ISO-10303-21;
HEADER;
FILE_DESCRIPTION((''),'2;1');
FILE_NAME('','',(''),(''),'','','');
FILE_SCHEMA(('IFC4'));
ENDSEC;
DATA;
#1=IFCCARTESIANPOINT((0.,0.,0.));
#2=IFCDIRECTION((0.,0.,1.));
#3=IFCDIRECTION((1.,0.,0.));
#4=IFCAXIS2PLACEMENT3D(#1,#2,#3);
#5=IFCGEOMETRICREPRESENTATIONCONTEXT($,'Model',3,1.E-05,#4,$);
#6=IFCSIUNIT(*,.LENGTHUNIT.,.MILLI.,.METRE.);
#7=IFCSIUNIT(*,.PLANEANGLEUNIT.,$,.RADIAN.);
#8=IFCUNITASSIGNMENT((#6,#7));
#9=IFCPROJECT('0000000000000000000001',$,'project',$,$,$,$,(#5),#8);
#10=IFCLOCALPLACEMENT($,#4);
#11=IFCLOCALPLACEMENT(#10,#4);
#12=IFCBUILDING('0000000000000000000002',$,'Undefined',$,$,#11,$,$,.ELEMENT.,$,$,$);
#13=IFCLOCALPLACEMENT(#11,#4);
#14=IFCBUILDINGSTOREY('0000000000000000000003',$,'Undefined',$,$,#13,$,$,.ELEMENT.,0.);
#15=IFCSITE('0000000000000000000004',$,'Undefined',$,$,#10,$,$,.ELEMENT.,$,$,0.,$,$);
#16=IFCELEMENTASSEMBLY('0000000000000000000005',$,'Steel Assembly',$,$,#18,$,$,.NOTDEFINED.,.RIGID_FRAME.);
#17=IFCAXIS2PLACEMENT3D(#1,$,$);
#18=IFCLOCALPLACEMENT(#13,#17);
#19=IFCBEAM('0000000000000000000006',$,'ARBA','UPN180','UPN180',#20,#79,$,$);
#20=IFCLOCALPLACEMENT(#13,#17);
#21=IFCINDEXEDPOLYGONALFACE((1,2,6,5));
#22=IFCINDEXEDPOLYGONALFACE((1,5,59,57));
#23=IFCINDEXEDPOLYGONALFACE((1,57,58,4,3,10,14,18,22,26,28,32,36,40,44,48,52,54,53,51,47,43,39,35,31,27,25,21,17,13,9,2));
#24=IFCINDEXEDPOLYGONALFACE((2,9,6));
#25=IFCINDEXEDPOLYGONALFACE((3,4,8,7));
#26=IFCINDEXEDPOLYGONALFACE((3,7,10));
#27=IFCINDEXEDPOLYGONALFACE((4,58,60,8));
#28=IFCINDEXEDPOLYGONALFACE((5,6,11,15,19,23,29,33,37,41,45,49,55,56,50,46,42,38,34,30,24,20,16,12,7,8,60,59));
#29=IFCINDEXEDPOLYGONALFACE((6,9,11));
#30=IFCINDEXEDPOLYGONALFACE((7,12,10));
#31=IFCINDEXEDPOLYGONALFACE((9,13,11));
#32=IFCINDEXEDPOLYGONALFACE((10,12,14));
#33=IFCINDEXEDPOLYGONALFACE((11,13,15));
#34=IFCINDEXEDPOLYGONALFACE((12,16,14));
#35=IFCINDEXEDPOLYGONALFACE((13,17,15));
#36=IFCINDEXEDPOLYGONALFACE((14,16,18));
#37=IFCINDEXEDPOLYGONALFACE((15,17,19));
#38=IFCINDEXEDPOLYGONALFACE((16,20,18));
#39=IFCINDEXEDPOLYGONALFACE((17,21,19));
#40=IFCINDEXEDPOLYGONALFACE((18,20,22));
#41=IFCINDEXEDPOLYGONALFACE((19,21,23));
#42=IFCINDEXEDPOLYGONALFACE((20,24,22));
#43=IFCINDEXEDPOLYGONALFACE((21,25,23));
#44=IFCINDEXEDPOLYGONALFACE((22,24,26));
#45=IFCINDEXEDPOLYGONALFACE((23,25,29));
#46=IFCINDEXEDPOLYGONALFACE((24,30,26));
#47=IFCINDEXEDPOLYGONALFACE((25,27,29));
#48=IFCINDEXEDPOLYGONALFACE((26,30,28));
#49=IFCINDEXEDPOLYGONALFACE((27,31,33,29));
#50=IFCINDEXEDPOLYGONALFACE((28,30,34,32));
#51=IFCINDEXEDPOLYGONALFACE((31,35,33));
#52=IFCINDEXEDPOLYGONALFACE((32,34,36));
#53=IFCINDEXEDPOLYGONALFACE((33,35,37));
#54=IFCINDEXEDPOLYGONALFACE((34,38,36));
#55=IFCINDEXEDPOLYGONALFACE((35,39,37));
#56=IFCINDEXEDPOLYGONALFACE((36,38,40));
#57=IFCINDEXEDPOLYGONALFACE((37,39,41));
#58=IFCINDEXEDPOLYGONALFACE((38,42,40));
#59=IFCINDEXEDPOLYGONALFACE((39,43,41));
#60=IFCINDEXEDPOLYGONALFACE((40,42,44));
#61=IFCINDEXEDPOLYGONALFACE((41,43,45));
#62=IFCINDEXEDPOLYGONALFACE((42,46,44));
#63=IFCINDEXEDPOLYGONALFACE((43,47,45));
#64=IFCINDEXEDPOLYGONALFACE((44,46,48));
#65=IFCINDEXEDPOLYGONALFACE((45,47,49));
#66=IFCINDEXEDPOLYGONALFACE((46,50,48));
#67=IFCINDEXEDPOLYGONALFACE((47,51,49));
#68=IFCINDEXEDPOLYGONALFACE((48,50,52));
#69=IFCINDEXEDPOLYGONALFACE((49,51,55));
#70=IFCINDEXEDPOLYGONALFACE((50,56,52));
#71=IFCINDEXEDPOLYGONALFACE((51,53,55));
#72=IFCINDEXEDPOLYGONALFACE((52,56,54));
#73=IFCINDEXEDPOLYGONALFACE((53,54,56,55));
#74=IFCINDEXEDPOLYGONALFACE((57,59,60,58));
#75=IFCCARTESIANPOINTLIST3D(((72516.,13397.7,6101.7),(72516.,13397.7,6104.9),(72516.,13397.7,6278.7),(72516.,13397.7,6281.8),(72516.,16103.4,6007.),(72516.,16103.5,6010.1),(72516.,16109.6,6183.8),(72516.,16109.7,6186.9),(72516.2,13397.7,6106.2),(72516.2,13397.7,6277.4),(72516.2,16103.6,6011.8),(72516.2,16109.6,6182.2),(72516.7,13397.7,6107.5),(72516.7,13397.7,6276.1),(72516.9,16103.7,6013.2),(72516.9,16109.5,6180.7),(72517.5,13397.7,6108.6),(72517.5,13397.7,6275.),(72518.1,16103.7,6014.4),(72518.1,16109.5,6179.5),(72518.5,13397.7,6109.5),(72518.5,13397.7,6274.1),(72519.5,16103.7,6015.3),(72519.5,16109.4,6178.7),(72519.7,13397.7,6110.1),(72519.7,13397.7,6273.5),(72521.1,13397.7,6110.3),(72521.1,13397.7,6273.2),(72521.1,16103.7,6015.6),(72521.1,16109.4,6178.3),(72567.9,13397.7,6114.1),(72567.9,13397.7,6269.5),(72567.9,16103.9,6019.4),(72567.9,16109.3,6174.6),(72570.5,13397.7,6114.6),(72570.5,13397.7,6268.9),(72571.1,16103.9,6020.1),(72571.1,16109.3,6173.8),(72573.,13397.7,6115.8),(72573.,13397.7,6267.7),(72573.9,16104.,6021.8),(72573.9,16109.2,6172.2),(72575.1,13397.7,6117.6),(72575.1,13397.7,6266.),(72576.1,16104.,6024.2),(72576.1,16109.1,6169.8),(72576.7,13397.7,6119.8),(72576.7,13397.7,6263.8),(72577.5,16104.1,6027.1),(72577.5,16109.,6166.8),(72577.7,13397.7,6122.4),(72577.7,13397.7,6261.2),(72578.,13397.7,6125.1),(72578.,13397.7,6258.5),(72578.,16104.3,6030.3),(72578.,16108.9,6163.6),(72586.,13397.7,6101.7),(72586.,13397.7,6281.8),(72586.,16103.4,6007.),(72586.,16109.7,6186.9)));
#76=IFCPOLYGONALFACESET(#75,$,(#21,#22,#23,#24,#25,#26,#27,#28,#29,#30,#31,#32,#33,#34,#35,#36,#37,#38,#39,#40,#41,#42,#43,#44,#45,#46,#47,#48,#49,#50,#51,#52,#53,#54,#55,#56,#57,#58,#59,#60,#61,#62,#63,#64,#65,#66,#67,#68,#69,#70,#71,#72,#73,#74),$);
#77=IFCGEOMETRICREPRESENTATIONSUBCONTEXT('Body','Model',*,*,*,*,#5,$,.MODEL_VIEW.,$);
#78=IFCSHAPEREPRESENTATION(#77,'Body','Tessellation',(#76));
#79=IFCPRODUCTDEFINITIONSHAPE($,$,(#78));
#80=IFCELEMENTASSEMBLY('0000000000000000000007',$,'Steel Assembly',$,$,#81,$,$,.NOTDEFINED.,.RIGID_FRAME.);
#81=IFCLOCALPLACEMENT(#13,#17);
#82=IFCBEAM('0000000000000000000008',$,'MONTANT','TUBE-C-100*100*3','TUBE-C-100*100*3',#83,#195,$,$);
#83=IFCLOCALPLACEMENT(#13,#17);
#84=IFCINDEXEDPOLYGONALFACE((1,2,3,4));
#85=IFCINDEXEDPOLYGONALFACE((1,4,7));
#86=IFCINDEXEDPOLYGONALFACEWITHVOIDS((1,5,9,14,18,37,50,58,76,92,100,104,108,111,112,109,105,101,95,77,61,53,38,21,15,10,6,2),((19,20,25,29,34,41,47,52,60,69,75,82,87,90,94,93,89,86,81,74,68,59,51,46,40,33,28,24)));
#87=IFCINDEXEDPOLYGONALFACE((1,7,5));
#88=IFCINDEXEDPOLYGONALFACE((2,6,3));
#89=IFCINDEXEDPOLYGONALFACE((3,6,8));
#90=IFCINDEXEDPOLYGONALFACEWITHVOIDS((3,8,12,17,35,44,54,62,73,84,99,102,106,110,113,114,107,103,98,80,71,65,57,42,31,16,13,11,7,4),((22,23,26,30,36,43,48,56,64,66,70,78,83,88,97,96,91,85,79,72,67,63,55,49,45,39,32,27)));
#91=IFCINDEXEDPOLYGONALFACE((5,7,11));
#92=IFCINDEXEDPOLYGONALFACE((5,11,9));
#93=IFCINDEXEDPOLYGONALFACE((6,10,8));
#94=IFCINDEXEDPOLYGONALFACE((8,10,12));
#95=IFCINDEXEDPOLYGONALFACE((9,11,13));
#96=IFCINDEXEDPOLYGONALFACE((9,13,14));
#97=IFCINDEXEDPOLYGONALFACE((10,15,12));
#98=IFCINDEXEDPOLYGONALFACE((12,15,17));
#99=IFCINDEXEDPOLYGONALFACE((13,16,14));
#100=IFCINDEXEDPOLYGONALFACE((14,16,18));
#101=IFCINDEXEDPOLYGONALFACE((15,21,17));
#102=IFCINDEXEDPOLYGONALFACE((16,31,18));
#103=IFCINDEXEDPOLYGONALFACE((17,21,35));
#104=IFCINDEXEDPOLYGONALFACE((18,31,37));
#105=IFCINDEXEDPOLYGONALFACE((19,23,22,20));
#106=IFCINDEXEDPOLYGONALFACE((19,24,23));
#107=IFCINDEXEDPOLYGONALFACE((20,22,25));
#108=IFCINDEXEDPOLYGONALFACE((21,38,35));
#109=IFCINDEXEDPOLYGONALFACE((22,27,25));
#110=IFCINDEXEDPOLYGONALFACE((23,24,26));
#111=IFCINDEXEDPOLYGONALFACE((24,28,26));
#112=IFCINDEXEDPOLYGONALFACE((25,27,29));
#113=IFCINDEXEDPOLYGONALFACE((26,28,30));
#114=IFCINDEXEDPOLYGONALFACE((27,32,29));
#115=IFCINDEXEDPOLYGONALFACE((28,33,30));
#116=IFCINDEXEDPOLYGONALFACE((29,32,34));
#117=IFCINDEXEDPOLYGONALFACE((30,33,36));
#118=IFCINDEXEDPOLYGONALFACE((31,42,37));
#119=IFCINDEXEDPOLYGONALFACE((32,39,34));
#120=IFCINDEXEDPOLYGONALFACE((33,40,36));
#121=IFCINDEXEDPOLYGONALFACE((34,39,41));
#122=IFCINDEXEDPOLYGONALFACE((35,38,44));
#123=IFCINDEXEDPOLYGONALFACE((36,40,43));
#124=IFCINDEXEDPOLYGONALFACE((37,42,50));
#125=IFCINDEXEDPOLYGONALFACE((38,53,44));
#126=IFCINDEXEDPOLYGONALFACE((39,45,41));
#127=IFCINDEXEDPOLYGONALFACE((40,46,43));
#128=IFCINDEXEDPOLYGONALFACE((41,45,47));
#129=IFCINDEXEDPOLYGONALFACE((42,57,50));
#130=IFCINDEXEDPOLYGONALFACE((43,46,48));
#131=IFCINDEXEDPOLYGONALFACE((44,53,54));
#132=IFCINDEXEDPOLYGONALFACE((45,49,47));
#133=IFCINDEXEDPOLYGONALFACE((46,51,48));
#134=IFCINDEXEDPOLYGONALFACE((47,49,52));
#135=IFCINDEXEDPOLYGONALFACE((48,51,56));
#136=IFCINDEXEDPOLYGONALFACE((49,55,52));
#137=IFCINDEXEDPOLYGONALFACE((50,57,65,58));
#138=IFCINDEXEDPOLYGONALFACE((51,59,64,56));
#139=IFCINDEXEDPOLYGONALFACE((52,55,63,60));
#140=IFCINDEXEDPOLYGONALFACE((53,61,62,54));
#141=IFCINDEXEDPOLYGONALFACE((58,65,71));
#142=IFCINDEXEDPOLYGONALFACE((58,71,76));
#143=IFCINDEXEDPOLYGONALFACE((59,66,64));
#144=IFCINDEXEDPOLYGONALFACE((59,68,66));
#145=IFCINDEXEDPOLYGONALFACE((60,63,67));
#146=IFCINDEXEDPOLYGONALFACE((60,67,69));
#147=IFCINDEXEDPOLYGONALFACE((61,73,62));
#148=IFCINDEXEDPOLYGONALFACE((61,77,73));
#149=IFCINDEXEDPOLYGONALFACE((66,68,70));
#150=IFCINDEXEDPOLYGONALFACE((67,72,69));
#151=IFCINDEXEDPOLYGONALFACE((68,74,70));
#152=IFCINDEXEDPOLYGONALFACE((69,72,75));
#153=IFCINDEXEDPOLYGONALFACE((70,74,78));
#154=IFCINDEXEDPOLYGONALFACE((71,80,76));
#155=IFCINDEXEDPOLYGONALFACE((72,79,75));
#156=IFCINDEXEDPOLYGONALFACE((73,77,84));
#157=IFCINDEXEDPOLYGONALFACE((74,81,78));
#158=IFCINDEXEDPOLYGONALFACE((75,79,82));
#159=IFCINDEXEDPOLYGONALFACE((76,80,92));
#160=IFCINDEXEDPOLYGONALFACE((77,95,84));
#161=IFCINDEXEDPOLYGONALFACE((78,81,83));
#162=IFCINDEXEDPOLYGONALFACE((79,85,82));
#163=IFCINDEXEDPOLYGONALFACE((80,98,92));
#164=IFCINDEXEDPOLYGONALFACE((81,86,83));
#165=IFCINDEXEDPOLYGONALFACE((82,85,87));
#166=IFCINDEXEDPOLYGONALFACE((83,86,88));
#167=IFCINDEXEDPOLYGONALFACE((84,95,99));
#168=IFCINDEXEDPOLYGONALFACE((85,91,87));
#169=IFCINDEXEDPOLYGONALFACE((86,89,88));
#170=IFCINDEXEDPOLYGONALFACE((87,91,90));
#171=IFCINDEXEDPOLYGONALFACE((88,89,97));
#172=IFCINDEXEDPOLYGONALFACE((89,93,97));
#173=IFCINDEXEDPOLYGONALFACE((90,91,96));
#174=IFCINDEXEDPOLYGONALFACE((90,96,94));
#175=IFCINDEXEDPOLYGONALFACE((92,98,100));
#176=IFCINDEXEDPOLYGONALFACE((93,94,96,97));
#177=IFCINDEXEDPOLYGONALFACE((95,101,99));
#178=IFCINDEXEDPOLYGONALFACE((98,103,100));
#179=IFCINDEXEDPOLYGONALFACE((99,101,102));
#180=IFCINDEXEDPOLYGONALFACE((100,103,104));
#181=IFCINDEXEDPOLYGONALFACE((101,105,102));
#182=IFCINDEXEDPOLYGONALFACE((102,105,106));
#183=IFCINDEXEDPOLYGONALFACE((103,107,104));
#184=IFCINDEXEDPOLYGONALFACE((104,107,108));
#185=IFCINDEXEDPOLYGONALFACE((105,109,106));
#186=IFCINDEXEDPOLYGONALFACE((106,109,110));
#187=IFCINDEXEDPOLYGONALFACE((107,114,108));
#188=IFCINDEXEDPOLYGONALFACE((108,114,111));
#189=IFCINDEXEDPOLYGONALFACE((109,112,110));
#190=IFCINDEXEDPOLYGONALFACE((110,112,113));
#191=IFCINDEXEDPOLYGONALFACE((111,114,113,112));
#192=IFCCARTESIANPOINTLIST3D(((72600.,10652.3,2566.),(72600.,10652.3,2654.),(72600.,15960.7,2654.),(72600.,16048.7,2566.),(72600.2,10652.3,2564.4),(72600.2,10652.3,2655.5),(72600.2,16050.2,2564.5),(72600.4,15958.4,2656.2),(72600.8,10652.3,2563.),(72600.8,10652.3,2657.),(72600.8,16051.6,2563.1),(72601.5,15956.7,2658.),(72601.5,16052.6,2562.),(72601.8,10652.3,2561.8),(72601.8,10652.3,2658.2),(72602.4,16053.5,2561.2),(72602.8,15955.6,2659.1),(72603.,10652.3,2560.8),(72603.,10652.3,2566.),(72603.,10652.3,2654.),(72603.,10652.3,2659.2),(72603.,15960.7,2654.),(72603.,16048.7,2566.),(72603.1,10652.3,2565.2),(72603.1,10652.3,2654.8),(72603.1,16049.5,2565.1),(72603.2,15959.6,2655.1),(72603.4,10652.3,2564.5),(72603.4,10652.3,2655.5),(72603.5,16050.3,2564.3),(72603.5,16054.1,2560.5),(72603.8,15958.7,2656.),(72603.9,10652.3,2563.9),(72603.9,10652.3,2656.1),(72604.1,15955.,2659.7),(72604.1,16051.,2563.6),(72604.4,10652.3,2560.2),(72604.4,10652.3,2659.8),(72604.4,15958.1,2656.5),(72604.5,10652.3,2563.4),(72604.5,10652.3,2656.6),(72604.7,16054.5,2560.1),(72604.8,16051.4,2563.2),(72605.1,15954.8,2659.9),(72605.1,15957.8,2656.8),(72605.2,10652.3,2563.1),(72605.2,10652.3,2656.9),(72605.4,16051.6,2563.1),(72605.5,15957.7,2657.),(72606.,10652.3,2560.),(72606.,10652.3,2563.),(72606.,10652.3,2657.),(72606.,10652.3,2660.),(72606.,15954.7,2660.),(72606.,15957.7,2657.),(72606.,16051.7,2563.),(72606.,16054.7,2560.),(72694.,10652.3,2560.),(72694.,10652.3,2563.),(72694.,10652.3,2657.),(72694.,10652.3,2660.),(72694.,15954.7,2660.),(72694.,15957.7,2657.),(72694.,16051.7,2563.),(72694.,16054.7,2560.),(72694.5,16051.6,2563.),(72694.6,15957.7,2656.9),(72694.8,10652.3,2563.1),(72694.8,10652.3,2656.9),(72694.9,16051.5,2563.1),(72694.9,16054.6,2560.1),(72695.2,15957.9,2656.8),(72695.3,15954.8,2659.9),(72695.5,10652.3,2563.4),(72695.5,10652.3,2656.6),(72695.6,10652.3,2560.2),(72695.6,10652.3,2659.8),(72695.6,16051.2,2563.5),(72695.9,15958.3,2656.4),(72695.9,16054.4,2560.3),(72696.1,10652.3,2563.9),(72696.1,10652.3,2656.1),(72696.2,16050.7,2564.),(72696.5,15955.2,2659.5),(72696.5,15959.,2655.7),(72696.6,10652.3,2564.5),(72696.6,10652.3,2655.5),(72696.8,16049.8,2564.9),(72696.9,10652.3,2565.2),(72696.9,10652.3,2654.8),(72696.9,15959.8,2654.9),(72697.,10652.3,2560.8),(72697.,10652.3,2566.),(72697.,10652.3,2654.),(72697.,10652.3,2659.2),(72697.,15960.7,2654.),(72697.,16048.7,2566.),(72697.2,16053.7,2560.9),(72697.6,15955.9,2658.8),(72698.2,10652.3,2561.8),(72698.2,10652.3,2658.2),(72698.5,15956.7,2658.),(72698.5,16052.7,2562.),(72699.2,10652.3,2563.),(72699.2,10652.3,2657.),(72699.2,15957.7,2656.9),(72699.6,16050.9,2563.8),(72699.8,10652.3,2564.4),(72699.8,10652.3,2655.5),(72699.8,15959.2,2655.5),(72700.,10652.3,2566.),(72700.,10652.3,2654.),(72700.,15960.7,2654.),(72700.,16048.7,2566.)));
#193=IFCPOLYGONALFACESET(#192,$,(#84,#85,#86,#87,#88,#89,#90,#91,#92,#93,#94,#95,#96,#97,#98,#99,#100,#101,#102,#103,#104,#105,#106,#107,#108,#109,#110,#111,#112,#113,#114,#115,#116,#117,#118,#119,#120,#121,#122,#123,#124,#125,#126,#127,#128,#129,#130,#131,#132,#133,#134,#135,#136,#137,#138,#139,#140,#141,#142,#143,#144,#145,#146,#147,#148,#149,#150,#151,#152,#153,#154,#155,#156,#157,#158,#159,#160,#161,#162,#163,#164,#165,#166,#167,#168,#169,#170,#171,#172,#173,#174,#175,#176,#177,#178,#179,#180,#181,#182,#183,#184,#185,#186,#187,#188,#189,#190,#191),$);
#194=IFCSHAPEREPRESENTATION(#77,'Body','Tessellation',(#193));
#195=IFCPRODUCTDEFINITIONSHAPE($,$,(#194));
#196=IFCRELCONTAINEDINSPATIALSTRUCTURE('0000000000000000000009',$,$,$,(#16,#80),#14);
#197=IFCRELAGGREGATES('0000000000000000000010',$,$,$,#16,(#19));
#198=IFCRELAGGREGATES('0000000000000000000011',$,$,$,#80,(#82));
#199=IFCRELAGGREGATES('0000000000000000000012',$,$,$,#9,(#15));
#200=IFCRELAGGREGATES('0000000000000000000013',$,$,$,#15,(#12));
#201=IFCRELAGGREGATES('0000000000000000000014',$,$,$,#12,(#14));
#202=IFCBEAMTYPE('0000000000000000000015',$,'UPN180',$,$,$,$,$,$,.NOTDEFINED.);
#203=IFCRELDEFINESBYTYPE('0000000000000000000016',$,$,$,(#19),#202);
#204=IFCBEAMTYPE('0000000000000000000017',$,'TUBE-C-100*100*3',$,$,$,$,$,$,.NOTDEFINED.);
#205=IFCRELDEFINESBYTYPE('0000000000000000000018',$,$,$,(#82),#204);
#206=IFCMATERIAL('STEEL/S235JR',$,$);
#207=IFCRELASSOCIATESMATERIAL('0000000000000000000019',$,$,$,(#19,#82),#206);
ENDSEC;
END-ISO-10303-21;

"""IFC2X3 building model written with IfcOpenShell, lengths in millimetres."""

from ifc_helpers import new_model, si_unit, frame, origin_with_axes, origin_2d_with_axis, place, context, subcontext, project, spatial, hollow_rectangle, u_section, extrude, clip, halfspace, material, type_object, element, aggregate, save


model = new_model("IFC2X3")

# Units and contexts
model_context = context("Model", 3, precision=1e-05, world=origin_with_axes())
body_context = subcontext(model_context, "Body", "Model", "MODEL_VIEW")
ifc_project = project(units=[si_unit("LENGTHUNIT", "METRE", prefix="MILLI"), si_unit("PLANEANGLEUNIT", "RADIAN")], contexts=[model_context])

# Site, building, storey
site_placement = place(None, origin_with_axes())
site = spatial("IfcSite", under=ifc_project, at=site_placement, Name="Undefined", CompositionType="ELEMENT", RefElevation=0.0)
building_placement = place(site_placement, origin_with_axes())
building = spatial("IfcBuilding", under=site, at=building_placement, Name="Undefined", CompositionType="ELEMENT")
storey_placement = place(building_placement, origin_with_axes())
storey = spatial("IfcBuildingStorey", under=building, at=storey_placement, Name="Undefined", CompositionType="ELEMENT", Elevation=0.0)

# Shared definitions
ifc_material_1 = material(Name="STEEL/S235JR")

# Element assemblies, beams
assembly_1_placement = place(storey_placement, origin_with_axes())
assembly_1 = element("IfcElementAssembly", 1, at=assembly_1_placement, inside=storey, Name="Steel Assembly", AssemblyPlace="NOTDEFINED", PredefinedType="RIGID_FRAME")
beam_type_1 = type_object("IfcBeamType", Name="UPN180", PredefinedType="NOTDEFINED")
beam_1_placement = place(assembly_1_placement, frame((72551.0, 16106.5, 6097.0), z_axis=(0.0, 0.034979, 0.999388), x_axis=(0.0, -0.999388, 0.034979)))
beam_1 = element("IfcBeam", 2, at=beam_1_placement, type_object=beam_type_1, material=ifc_material_1, Name="ARBA", Description="UPN180", ObjectType="UPN180", context=body_context, shape_type="Clipping", body=[
    clip(extrude(u_section(Depth=180.0, FlangeWidth=70.0, WebThickness=8.0, FlangeThickness=11.0, FilletRadius=11.0, EdgeRadius=5.5, FlangeSlope=0.07983, at=origin_2d_with_axis()), frame((2720.1, 0.0, 0.0), z_axis=(-1.0, 0.0, 0.0), x_axis=(0.0, -1.0, 0.0)), (0.0, 0.0, 1.0), 2720.1), halfspace(frame((2713.7, 0.0, 90.0), z_axis=(-0.999388, 0.0, 0.034979), x_axis=(0.0, -1.0, 0.0)), True)),
])
assembly_2_placement = place(storey_placement, origin_with_axes())
assembly_2 = element("IfcElementAssembly", 3, at=assembly_2_placement, inside=storey, Name="Steel Assembly", AssemblyPlace="NOTDEFINED", PredefinedType="RIGID_FRAME")
beam_type_2 = type_object("IfcBeamType", Name="TUBE-C-100*100*3", PredefinedType="NOTDEFINED")
beam_2_placement = place(assembly_2_placement, frame((72650.0, 16114.7, 2610.0), z_axis=(0.0, 0.0, 1.0), x_axis=(0.0, -1.0, 0.0)))
beam_2 = element("IfcBeam", 4, at=beam_2_placement, type_object=beam_type_2, material=ifc_material_1, Name="MONTANT", Description="TUBE-C-100*100*3", ObjectType="TUBE-C-100*100*3", context=body_context, shape_type="Clipping", body=[
    clip(extrude(hollow_rectangle(XDim=100.0, YDim=100.0, WallThickness=3.0, InnerFilletRadius=3.0, OuterFilletRadius=6.0, at=origin_2d_with_axis()), frame((5462.3, 0.0, 0.0), z_axis=(-1.0, 0.0, 0.0), x_axis=(0.0, -1.0, 0.0)), (0.0, 0.0, 1.0), 5462.3), halfspace(frame((60.0, 50.0, -50.0), z_axis=(-0.707107, 0.0, 0.707107), x_axis=(0.707107, 0.0, 0.707107)), False)),
])

aggregate(assembly_1, [beam_1])
aggregate(assembly_2, [beam_2])

save(model, "model.ifc")
